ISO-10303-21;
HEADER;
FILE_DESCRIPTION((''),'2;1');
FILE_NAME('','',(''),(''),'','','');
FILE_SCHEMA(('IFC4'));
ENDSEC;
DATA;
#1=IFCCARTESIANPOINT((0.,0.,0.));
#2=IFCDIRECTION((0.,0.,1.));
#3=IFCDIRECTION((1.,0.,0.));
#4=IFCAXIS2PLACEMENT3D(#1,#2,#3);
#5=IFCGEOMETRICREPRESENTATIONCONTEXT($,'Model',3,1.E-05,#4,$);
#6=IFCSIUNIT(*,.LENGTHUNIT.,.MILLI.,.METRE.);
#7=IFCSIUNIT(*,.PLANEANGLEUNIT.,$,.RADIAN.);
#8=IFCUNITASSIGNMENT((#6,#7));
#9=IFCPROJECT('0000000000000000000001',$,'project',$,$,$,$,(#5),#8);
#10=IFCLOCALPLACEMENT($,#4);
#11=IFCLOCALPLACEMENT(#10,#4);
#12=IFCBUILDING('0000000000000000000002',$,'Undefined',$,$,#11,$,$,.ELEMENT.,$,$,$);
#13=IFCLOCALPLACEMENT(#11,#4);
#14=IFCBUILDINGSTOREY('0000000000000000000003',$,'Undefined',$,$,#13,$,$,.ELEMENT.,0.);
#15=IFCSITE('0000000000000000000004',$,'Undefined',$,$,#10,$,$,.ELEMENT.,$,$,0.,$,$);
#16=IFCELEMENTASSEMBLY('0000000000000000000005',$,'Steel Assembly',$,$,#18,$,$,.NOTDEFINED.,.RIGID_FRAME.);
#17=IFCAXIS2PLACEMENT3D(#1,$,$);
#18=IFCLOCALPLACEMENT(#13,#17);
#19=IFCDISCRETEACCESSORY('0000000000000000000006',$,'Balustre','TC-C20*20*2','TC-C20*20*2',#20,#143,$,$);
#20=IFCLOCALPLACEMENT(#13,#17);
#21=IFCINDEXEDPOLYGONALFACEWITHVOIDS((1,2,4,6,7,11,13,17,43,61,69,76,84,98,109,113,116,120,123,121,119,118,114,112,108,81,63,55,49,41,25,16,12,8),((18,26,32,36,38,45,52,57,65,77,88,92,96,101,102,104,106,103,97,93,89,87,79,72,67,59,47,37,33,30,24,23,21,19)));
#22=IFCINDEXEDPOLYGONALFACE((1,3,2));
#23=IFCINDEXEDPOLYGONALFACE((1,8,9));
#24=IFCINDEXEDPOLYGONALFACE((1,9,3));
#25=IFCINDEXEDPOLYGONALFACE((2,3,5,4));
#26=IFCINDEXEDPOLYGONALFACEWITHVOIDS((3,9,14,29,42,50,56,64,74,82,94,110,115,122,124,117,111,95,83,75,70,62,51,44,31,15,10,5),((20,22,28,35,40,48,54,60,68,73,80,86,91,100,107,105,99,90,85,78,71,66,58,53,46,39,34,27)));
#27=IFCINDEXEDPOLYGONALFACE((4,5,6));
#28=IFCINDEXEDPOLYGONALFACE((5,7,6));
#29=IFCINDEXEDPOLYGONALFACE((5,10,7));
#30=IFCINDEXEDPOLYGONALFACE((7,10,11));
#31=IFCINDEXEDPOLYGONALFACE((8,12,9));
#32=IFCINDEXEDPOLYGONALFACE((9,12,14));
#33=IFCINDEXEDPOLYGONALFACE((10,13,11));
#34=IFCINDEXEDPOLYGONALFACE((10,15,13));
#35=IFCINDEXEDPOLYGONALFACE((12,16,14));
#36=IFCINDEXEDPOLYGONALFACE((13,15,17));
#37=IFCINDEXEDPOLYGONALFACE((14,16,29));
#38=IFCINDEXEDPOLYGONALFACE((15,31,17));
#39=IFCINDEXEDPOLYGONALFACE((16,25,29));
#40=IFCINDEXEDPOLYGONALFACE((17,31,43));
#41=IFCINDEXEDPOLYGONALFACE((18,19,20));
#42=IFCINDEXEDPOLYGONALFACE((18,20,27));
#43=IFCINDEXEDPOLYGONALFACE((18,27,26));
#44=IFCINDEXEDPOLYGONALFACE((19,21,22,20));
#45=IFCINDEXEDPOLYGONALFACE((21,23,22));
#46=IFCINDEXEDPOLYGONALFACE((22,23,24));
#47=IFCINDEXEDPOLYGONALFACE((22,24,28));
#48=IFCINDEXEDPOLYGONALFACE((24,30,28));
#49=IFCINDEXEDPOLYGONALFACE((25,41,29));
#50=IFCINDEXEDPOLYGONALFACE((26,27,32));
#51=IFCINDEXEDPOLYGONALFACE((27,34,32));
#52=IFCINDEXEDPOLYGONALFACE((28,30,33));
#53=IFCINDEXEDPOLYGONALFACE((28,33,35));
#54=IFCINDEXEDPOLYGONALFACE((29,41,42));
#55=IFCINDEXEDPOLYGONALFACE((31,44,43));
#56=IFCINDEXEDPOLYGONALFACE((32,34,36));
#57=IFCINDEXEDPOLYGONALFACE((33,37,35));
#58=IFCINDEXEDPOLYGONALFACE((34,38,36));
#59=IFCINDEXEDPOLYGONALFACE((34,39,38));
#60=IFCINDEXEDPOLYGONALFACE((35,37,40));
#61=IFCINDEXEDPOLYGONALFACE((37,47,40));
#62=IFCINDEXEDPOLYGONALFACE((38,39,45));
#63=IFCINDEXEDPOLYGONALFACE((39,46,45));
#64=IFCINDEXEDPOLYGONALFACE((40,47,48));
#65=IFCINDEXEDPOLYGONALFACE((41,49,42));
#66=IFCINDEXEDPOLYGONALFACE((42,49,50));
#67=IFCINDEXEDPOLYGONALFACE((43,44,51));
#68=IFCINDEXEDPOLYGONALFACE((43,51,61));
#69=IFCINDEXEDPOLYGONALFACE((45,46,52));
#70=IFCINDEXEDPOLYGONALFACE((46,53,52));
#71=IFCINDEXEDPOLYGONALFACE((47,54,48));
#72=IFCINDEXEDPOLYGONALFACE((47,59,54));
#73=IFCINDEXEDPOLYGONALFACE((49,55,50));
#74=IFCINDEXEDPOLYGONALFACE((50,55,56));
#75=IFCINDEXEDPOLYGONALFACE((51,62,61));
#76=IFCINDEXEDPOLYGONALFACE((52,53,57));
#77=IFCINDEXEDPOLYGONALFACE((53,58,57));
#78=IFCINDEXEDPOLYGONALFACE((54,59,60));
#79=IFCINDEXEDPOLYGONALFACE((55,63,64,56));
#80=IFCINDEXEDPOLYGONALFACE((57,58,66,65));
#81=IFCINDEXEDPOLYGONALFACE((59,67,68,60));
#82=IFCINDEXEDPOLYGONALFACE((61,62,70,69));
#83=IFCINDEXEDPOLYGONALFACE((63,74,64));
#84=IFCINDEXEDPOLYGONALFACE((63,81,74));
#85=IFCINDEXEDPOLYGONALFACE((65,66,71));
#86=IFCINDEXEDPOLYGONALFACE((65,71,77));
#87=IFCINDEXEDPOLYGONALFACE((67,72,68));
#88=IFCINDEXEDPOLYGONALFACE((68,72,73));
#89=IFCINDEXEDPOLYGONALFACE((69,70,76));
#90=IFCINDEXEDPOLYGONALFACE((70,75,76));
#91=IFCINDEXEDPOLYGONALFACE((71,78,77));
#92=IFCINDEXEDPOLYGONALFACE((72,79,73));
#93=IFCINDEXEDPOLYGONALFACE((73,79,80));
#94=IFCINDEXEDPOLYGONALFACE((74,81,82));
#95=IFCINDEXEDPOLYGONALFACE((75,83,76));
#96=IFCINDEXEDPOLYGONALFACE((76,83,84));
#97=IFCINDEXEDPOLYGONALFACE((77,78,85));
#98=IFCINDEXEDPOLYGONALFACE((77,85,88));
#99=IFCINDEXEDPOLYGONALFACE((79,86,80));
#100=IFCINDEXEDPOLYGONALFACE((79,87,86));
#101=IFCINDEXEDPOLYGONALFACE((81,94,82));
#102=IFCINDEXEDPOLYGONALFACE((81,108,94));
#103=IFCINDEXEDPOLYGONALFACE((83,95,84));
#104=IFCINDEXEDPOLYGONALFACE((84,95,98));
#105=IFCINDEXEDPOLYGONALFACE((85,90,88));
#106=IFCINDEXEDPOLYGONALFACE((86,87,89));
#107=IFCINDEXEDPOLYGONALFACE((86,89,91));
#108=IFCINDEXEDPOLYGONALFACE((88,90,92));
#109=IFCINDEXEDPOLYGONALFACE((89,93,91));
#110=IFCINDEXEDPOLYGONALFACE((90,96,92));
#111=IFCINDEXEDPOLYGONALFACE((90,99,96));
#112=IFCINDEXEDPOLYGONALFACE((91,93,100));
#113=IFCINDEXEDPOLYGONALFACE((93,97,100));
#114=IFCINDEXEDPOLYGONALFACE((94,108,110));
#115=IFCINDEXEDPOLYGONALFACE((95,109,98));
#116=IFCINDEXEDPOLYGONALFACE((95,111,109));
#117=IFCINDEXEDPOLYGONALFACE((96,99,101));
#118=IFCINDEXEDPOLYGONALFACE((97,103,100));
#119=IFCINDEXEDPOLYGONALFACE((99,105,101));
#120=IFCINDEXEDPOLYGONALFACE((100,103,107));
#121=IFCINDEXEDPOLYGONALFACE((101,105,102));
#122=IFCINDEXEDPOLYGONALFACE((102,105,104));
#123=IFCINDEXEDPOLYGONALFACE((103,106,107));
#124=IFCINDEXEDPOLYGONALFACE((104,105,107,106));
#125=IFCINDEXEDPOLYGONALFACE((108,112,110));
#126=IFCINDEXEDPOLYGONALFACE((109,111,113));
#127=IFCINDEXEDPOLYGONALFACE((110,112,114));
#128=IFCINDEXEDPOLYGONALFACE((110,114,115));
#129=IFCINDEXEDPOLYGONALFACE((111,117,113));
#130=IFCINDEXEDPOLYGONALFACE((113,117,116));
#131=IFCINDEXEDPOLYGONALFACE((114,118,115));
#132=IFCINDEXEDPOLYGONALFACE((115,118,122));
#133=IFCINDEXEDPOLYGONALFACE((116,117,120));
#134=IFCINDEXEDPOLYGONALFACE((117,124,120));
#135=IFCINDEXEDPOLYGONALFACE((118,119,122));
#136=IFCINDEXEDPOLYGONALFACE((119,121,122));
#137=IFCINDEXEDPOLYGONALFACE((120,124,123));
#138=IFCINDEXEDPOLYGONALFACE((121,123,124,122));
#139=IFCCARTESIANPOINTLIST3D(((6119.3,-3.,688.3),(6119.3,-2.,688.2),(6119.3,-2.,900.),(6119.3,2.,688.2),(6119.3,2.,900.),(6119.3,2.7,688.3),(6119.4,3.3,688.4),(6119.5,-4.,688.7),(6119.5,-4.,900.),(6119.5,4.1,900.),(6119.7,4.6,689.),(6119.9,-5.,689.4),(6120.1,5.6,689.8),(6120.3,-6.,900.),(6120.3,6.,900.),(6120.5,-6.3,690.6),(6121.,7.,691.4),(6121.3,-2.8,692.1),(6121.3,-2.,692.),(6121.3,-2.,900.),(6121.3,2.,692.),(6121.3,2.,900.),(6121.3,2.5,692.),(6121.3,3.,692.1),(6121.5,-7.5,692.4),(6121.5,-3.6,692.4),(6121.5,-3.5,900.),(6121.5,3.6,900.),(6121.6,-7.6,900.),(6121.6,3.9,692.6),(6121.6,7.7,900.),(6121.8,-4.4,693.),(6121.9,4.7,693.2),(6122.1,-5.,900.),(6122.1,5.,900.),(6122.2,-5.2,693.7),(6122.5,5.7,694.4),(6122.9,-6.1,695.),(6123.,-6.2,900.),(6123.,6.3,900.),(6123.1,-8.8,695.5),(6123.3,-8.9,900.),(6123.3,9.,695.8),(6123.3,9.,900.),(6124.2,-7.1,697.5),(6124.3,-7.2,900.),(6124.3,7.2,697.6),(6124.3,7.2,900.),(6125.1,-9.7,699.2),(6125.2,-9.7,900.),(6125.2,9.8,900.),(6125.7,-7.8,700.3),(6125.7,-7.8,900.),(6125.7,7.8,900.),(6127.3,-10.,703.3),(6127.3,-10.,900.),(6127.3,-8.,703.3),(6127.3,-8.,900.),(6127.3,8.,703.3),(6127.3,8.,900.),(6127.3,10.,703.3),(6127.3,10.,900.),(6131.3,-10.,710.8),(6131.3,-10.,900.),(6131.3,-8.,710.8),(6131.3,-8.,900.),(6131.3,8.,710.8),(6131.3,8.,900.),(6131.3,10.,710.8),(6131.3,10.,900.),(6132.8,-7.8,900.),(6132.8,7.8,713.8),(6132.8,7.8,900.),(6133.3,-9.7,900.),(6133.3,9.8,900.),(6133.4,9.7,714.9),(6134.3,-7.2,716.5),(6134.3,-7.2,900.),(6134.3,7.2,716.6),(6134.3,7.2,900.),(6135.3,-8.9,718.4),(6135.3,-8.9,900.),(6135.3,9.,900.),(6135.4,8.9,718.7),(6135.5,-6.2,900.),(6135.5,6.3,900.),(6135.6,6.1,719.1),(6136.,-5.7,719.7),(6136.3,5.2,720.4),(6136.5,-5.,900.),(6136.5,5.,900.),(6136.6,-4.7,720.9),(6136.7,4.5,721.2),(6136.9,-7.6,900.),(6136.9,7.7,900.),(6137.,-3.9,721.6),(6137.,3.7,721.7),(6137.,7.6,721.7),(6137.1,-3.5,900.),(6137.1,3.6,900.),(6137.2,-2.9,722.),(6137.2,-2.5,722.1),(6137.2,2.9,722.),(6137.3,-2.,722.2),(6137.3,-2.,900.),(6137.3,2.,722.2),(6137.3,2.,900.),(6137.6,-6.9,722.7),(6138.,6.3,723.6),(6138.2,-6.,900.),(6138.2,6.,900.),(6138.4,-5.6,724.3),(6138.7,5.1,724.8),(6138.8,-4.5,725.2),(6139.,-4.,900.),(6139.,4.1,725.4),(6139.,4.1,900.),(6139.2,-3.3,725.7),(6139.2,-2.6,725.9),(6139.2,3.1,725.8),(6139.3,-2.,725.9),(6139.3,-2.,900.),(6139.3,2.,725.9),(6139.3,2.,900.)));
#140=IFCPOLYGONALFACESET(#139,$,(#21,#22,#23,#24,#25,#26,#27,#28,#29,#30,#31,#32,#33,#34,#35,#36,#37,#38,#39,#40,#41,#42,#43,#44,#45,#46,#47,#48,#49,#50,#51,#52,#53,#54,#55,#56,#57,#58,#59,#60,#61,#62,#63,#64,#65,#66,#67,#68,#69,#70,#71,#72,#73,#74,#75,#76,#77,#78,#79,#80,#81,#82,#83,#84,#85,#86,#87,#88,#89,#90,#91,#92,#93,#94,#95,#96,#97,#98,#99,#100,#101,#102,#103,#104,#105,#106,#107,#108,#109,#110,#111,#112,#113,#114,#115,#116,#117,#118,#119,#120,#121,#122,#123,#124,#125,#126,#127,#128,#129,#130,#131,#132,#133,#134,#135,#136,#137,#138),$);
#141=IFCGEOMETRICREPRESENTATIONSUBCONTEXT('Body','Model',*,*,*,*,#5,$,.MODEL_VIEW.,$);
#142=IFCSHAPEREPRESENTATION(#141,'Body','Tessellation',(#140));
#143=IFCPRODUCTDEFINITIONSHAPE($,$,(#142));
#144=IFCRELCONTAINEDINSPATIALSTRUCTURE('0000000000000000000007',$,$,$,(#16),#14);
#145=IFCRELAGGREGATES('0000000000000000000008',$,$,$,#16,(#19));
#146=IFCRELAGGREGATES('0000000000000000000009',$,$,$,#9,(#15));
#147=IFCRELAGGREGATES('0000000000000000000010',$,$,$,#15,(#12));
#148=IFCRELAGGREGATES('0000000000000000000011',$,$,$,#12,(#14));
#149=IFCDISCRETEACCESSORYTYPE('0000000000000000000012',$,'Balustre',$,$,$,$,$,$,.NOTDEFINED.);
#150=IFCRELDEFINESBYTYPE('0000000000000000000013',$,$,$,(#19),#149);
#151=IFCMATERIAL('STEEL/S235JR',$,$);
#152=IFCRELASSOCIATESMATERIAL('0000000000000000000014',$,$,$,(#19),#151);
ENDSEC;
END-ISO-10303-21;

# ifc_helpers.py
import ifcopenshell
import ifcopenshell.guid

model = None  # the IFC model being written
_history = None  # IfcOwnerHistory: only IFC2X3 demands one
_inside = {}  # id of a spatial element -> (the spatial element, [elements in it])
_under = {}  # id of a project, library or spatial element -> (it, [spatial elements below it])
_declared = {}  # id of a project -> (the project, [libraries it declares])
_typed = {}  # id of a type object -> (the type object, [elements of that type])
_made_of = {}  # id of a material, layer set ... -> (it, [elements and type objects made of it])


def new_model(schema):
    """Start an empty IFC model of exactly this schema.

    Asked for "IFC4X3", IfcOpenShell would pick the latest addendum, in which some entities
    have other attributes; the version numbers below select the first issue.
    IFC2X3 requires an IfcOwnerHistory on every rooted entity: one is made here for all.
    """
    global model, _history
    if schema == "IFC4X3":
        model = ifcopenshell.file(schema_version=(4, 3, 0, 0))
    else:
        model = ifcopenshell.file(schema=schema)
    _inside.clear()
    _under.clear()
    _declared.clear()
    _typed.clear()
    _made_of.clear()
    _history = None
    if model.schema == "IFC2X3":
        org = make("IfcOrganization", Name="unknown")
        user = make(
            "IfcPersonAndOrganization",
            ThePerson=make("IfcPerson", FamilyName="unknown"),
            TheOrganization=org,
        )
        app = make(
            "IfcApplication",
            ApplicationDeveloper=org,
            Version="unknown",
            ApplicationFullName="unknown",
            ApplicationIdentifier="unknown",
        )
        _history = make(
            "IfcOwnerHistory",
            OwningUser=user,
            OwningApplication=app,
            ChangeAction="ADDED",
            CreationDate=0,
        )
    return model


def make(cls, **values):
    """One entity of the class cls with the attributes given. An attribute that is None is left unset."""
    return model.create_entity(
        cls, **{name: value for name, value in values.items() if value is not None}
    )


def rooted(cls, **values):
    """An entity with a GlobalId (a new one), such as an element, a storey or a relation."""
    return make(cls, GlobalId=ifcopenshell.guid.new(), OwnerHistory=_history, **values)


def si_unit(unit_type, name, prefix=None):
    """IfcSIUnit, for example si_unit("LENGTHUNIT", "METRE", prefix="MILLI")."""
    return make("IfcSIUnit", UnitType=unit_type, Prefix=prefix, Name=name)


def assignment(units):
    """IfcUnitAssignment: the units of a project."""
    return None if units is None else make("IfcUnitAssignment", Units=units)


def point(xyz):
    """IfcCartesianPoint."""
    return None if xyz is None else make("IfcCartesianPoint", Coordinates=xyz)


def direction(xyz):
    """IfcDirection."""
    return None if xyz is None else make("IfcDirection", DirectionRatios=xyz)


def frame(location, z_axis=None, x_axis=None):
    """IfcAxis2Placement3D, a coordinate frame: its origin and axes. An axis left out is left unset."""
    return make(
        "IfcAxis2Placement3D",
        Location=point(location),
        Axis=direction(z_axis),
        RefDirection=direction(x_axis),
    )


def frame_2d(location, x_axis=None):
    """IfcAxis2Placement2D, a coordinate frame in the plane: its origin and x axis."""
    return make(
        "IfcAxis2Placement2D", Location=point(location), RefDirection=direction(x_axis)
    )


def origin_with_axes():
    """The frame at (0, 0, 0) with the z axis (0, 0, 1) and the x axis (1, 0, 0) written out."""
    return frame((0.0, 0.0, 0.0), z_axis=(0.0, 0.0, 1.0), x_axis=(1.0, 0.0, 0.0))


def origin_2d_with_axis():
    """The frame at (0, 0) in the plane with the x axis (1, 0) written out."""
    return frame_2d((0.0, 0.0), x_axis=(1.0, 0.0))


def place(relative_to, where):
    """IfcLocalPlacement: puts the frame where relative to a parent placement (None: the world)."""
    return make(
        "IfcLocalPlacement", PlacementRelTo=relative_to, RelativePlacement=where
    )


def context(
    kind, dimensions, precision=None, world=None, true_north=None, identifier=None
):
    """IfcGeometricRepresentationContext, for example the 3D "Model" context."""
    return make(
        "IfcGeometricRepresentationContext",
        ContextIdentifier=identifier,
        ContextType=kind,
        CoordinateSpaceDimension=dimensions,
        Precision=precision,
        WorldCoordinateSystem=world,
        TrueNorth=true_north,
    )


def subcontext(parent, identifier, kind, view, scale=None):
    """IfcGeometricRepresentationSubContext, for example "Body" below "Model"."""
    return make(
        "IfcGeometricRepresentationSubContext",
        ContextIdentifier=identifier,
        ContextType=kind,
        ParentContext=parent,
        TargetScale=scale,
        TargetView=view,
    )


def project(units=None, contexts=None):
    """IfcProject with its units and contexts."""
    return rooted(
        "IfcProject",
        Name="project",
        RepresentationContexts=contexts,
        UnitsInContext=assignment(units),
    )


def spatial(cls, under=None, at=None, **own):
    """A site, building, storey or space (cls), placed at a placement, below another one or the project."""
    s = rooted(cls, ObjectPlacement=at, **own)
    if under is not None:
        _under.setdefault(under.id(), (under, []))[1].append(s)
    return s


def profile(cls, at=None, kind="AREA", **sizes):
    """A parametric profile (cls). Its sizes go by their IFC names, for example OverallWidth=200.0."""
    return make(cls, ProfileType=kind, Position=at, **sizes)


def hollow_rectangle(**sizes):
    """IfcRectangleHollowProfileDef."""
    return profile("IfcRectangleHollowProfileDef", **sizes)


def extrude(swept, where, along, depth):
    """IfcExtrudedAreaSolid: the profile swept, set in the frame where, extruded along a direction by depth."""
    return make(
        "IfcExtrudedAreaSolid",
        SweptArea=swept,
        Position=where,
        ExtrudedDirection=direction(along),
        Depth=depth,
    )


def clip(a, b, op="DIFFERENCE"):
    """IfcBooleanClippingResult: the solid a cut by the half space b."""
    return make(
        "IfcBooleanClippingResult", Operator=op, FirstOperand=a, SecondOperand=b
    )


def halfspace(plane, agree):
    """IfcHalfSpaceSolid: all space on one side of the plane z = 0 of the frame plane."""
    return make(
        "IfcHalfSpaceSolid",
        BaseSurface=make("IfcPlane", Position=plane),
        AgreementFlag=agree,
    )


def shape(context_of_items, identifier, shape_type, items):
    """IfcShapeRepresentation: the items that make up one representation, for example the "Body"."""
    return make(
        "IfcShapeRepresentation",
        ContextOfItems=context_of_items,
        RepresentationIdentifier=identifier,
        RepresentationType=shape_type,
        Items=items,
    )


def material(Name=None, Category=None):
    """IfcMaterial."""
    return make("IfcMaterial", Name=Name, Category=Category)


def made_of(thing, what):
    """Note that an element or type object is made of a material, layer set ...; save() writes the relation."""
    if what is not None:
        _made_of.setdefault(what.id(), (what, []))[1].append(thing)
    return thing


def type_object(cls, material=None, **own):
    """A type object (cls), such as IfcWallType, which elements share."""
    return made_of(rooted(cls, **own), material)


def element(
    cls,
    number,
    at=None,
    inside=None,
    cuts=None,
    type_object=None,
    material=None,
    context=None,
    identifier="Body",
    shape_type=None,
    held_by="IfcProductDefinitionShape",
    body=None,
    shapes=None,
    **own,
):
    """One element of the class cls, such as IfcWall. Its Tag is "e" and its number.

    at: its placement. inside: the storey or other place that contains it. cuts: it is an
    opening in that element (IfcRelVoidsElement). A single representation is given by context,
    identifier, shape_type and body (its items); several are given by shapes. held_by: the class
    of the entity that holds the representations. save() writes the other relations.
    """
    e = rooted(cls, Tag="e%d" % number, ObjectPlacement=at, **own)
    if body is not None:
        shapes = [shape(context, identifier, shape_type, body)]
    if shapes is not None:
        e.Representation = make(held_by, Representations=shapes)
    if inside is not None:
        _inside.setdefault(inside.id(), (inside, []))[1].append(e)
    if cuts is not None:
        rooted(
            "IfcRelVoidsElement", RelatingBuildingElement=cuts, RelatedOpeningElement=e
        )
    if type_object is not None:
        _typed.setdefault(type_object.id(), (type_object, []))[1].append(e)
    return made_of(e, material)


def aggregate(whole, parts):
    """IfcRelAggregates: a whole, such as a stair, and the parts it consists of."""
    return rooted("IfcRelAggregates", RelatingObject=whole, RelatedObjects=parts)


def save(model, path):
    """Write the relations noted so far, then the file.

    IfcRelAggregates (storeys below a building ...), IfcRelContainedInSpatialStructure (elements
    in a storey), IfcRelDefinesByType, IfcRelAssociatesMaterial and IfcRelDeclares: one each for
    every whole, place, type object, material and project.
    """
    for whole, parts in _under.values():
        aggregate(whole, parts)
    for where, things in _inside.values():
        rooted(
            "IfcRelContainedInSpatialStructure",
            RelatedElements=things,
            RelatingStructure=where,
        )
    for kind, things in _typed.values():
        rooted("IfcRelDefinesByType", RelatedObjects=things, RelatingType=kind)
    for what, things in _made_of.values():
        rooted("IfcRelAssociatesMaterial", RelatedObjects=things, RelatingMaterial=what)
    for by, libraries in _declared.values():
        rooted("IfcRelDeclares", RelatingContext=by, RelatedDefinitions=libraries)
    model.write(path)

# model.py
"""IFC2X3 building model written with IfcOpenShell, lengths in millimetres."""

from ifc_helpers import new_model, si_unit, frame, origin_with_axes, origin_2d_with_axis, place, context, subcontext, project, spatial, hollow_rectangle, extrude, clip, halfspace, material, type_object, element, aggregate, save


model = new_model("IFC2X3")

# Units and contexts
model_context = context("Model", 3, precision=1e-05, world=origin_with_axes())
body_context = subcontext(model_context, "Body", "Model", "MODEL_VIEW")
ifc_project = project(units=[si_unit("LENGTHUNIT", "METRE", prefix="MILLI"), si_unit("PLANEANGLEUNIT", "RADIAN")], contexts=[model_context])

# Site, building, storey
site_placement = place(None, origin_with_axes())
site = spatial("IfcSite", under=ifc_project, at=site_placement, Name="Undefined", CompositionType="ELEMENT", RefElevation=0.0)
building_placement = place(site_placement, origin_with_axes())
building = spatial("IfcBuilding", under=site, at=building_placement, Name="Undefined", CompositionType="ELEMENT")
storey_placement = place(building_placement, origin_with_axes())
storey = spatial("IfcBuildingStorey", under=building, at=storey_placement, Name="Undefined", CompositionType="ELEMENT", Elevation=0.0)

# Element assembly
ifc_material = material(Name="STEEL/S235JR")
assembly_1_placement = place(storey_placement, origin_with_axes())
assembly_1 = element("IfcElementAssembly", 1, at=assembly_1_placement, inside=storey, Name="Steel Assembly", AssemblyPlace="NOTDEFINED", PredefinedType="RIGID_FRAME")

# Discrete accessory
discrete_accessory_type_1 = type_object("IfcDiscreteAccessoryType", Name="Balustre")
discrete_accessory_1_placement = place(assembly_1_placement, frame((6129.3, 0.0, 900.0), z_axis=(-0.000011, 1.0, 0.0), x_axis=(0.0, 0.0, -1.0)))
discrete_accessory_1 = element("IfcDiscreteAccessory", 2, at=discrete_accessory_1_placement, type_object=discrete_accessory_type_1, material=ifc_material, Name="Balustre", Description="TC-C20*20*2", ObjectType="TC-C20*20*2", context=body_context, shape_type="Clipping", body=[
    clip(extrude(hollow_rectangle(XDim=20.0, YDim=20.0, WallThickness=2.0, InnerFilletRadius=6.0, OuterFilletRadius=8.0, at=origin_2d_with_axis()), frame((212.0, 0.0, 0.0), z_axis=(-1.0, 0.0, 0.0), x_axis=(0.0, -1.0, 0.0)), (0.0, 0.0, 1.0), 212.0), halfspace(frame((221.5, 15.1, 0.0), z_axis=(-0.46842, 0.883506, 0.000005), x_axis=(0.0, -0.000005, 1.0)), True)),
])
aggregate(assembly_1, [discrete_accessory_1])

save(model, "model.ifc")
